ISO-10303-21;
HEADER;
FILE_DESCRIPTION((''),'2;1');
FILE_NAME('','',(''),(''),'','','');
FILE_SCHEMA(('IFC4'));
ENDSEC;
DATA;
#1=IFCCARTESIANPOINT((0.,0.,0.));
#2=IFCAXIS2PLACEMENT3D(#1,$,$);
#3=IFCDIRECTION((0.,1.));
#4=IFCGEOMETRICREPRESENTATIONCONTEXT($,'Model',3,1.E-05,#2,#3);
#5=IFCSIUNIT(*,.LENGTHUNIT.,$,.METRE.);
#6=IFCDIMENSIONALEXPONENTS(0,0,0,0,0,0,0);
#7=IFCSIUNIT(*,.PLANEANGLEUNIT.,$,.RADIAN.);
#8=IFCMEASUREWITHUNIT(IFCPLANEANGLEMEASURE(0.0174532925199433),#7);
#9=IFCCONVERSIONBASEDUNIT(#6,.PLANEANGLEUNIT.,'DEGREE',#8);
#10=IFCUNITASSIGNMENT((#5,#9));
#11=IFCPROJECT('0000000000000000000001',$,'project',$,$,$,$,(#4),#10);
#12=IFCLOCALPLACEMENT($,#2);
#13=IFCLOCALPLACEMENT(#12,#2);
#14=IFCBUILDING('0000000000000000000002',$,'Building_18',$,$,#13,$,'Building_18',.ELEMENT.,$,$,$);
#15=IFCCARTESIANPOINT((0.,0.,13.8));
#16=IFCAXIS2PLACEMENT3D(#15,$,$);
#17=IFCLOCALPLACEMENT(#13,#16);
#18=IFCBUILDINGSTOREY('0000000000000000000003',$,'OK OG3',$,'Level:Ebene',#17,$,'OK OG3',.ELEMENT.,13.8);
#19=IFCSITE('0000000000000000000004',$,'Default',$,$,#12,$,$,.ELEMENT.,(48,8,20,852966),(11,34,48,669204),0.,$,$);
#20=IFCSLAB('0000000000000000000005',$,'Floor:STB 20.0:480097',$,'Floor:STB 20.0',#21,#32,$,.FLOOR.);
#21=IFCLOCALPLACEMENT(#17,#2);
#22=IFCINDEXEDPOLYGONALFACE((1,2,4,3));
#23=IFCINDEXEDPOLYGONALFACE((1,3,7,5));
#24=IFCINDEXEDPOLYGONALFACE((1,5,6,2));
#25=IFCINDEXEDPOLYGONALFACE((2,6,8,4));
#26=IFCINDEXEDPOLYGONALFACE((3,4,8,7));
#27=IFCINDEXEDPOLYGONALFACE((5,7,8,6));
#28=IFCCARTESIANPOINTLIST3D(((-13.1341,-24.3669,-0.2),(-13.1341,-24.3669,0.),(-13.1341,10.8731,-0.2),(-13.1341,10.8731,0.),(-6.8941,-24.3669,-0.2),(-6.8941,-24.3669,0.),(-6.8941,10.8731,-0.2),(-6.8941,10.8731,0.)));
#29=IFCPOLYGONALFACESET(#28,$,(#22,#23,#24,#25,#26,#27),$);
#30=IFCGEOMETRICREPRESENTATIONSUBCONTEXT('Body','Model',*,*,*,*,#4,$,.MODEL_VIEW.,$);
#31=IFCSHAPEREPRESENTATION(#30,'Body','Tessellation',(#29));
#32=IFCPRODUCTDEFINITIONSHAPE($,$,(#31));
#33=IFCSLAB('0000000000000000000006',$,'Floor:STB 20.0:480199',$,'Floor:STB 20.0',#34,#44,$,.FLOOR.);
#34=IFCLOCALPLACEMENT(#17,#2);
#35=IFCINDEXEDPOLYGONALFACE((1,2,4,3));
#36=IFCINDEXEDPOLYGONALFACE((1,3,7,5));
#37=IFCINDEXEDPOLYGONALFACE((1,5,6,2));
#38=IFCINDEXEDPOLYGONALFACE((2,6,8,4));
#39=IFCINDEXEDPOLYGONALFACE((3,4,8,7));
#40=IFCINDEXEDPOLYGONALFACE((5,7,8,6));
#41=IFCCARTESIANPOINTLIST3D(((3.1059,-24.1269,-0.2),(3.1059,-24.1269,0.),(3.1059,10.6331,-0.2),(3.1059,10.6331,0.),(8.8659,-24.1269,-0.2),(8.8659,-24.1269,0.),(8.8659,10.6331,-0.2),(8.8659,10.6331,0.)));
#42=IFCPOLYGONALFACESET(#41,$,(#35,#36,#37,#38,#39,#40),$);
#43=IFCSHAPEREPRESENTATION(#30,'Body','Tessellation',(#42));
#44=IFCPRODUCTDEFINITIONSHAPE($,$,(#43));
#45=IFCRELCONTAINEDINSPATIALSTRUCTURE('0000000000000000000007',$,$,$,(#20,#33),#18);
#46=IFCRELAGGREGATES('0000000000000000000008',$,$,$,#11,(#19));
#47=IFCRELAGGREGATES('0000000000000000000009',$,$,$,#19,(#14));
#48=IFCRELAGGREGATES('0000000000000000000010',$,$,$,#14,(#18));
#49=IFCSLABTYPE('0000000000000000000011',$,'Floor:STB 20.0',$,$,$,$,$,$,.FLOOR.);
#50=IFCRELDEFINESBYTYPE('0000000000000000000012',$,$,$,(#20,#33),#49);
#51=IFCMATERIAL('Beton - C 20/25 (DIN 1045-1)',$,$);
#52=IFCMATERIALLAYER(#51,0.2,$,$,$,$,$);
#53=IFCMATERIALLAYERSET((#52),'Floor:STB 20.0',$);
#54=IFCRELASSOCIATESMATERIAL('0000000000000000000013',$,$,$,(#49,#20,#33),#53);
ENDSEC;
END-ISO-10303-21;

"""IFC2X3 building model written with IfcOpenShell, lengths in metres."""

from ifc_helpers import new_model, entity, si_unit, converted_unit, direction, frame, frame_2d, origin, origin_2d_with_axis, place, context, subcontext, project, spatial, rectangle, extrude, material, layer, layer_set, layer_usage, type_object, element, save


model = new_model("IFC2X3")

# Units and contexts
model_context = context("Model", 3, precision=1e-05, world=origin(), true_north=direction((0.0, 1.0)))
body_context = subcontext(model_context, "Body", "Model", "MODEL_VIEW")
ifc_project = project(units=[si_unit("LENGTHUNIT", "METRE"), converted_unit("PLANEANGLEUNIT", "DEGREE", entity("IfcPlaneAngleMeasure", 0.0174532925199433), si_unit("PLANEANGLEUNIT", "RADIAN"), dimensions=[0, 0, 0, 0, 0, 0, 0])], contexts=[model_context])

# Site, building, storey
site_placement = place(None, origin())
site = spatial("IfcSite", under=ifc_project, at=site_placement, Name="Default", CompositionType="ELEMENT", RefLatitude=(48, 8, 20, 852966), RefLongitude=(11, 34, 48, 669204), RefElevation=0.0)
building_placement = place(site_placement, origin())
building = spatial("IfcBuilding", under=site, at=building_placement, Name="Building_18", LongName="Building_18", CompositionType="ELEMENT")
storey_placement = place(building_placement, frame((0.0, 0.0, 13.8)))
storey = spatial("IfcBuildingStorey", under=building, at=storey_placement, Name="OK OG3", ObjectType="Level:Ebene", LongName="OK OG3", CompositionType="ELEMENT", Elevation=13.8)

# Slabs
ifc_material = material(Name="Beton - C 20/25 (DIN 1045-1)")
ifc_layer = layer(ifc_material, 0.2)
ifc_layer_set = layer_set([ifc_layer], Name="Floor:STB 20.0")
ifc_layer_usage_1 = layer_usage(ifc_layer_set, "AXIS3", "POSITIVE", 0.0)
slab_type = type_object("IfcSlabType", Name="Floor:STB 20.0", PredefinedType="FLOOR", material=ifc_layer_set)
slab_1_placement = place(storey_placement, origin())
element("IfcSlab", 1, at=slab_1_placement, inside=storey, type_object=slab_type, material=ifc_layer_usage_1, Name="Floor:STB 20.0:480097", ObjectType="Floor:STB 20.0", PredefinedType="FLOOR", context=body_context, shape_type="SweptSolid", body=[
    extrude(rectangle(XDim=35.24, YDim=6.24, at=frame_2d((0.0, 0.0), x_axis=(1.0, 0.0))), frame((-10.0141, -6.7469, 0.0), z_axis=(0.0, 0.0, -1.0), x_axis=(0.0, 1.0, 0.0)), (0.0, 0.0, 1.0), 0.2),
])
ifc_layer_usage_2 = layer_usage(ifc_layer_set, "AXIS3", "POSITIVE", 0.0)
slab_2_placement = place(storey_placement, origin())
element("IfcSlab", 2, at=slab_2_placement, inside=storey, type_object=slab_type, material=ifc_layer_usage_2, Name="Floor:STB 20.0:480199", ObjectType="Floor:STB 20.0", PredefinedType="FLOOR", context=body_context, shape_type="SweptSolid", body=[
    extrude(rectangle(XDim=34.76, YDim=5.76, at=origin_2d_with_axis()), frame((5.9859, -6.7469, 0.0), z_axis=(0.0, 0.0, -1.0), x_axis=(0.0, 1.0, 0.0)), (0.0, 0.0, 1.0), 0.2),
])

save(model, "model.ifc")
